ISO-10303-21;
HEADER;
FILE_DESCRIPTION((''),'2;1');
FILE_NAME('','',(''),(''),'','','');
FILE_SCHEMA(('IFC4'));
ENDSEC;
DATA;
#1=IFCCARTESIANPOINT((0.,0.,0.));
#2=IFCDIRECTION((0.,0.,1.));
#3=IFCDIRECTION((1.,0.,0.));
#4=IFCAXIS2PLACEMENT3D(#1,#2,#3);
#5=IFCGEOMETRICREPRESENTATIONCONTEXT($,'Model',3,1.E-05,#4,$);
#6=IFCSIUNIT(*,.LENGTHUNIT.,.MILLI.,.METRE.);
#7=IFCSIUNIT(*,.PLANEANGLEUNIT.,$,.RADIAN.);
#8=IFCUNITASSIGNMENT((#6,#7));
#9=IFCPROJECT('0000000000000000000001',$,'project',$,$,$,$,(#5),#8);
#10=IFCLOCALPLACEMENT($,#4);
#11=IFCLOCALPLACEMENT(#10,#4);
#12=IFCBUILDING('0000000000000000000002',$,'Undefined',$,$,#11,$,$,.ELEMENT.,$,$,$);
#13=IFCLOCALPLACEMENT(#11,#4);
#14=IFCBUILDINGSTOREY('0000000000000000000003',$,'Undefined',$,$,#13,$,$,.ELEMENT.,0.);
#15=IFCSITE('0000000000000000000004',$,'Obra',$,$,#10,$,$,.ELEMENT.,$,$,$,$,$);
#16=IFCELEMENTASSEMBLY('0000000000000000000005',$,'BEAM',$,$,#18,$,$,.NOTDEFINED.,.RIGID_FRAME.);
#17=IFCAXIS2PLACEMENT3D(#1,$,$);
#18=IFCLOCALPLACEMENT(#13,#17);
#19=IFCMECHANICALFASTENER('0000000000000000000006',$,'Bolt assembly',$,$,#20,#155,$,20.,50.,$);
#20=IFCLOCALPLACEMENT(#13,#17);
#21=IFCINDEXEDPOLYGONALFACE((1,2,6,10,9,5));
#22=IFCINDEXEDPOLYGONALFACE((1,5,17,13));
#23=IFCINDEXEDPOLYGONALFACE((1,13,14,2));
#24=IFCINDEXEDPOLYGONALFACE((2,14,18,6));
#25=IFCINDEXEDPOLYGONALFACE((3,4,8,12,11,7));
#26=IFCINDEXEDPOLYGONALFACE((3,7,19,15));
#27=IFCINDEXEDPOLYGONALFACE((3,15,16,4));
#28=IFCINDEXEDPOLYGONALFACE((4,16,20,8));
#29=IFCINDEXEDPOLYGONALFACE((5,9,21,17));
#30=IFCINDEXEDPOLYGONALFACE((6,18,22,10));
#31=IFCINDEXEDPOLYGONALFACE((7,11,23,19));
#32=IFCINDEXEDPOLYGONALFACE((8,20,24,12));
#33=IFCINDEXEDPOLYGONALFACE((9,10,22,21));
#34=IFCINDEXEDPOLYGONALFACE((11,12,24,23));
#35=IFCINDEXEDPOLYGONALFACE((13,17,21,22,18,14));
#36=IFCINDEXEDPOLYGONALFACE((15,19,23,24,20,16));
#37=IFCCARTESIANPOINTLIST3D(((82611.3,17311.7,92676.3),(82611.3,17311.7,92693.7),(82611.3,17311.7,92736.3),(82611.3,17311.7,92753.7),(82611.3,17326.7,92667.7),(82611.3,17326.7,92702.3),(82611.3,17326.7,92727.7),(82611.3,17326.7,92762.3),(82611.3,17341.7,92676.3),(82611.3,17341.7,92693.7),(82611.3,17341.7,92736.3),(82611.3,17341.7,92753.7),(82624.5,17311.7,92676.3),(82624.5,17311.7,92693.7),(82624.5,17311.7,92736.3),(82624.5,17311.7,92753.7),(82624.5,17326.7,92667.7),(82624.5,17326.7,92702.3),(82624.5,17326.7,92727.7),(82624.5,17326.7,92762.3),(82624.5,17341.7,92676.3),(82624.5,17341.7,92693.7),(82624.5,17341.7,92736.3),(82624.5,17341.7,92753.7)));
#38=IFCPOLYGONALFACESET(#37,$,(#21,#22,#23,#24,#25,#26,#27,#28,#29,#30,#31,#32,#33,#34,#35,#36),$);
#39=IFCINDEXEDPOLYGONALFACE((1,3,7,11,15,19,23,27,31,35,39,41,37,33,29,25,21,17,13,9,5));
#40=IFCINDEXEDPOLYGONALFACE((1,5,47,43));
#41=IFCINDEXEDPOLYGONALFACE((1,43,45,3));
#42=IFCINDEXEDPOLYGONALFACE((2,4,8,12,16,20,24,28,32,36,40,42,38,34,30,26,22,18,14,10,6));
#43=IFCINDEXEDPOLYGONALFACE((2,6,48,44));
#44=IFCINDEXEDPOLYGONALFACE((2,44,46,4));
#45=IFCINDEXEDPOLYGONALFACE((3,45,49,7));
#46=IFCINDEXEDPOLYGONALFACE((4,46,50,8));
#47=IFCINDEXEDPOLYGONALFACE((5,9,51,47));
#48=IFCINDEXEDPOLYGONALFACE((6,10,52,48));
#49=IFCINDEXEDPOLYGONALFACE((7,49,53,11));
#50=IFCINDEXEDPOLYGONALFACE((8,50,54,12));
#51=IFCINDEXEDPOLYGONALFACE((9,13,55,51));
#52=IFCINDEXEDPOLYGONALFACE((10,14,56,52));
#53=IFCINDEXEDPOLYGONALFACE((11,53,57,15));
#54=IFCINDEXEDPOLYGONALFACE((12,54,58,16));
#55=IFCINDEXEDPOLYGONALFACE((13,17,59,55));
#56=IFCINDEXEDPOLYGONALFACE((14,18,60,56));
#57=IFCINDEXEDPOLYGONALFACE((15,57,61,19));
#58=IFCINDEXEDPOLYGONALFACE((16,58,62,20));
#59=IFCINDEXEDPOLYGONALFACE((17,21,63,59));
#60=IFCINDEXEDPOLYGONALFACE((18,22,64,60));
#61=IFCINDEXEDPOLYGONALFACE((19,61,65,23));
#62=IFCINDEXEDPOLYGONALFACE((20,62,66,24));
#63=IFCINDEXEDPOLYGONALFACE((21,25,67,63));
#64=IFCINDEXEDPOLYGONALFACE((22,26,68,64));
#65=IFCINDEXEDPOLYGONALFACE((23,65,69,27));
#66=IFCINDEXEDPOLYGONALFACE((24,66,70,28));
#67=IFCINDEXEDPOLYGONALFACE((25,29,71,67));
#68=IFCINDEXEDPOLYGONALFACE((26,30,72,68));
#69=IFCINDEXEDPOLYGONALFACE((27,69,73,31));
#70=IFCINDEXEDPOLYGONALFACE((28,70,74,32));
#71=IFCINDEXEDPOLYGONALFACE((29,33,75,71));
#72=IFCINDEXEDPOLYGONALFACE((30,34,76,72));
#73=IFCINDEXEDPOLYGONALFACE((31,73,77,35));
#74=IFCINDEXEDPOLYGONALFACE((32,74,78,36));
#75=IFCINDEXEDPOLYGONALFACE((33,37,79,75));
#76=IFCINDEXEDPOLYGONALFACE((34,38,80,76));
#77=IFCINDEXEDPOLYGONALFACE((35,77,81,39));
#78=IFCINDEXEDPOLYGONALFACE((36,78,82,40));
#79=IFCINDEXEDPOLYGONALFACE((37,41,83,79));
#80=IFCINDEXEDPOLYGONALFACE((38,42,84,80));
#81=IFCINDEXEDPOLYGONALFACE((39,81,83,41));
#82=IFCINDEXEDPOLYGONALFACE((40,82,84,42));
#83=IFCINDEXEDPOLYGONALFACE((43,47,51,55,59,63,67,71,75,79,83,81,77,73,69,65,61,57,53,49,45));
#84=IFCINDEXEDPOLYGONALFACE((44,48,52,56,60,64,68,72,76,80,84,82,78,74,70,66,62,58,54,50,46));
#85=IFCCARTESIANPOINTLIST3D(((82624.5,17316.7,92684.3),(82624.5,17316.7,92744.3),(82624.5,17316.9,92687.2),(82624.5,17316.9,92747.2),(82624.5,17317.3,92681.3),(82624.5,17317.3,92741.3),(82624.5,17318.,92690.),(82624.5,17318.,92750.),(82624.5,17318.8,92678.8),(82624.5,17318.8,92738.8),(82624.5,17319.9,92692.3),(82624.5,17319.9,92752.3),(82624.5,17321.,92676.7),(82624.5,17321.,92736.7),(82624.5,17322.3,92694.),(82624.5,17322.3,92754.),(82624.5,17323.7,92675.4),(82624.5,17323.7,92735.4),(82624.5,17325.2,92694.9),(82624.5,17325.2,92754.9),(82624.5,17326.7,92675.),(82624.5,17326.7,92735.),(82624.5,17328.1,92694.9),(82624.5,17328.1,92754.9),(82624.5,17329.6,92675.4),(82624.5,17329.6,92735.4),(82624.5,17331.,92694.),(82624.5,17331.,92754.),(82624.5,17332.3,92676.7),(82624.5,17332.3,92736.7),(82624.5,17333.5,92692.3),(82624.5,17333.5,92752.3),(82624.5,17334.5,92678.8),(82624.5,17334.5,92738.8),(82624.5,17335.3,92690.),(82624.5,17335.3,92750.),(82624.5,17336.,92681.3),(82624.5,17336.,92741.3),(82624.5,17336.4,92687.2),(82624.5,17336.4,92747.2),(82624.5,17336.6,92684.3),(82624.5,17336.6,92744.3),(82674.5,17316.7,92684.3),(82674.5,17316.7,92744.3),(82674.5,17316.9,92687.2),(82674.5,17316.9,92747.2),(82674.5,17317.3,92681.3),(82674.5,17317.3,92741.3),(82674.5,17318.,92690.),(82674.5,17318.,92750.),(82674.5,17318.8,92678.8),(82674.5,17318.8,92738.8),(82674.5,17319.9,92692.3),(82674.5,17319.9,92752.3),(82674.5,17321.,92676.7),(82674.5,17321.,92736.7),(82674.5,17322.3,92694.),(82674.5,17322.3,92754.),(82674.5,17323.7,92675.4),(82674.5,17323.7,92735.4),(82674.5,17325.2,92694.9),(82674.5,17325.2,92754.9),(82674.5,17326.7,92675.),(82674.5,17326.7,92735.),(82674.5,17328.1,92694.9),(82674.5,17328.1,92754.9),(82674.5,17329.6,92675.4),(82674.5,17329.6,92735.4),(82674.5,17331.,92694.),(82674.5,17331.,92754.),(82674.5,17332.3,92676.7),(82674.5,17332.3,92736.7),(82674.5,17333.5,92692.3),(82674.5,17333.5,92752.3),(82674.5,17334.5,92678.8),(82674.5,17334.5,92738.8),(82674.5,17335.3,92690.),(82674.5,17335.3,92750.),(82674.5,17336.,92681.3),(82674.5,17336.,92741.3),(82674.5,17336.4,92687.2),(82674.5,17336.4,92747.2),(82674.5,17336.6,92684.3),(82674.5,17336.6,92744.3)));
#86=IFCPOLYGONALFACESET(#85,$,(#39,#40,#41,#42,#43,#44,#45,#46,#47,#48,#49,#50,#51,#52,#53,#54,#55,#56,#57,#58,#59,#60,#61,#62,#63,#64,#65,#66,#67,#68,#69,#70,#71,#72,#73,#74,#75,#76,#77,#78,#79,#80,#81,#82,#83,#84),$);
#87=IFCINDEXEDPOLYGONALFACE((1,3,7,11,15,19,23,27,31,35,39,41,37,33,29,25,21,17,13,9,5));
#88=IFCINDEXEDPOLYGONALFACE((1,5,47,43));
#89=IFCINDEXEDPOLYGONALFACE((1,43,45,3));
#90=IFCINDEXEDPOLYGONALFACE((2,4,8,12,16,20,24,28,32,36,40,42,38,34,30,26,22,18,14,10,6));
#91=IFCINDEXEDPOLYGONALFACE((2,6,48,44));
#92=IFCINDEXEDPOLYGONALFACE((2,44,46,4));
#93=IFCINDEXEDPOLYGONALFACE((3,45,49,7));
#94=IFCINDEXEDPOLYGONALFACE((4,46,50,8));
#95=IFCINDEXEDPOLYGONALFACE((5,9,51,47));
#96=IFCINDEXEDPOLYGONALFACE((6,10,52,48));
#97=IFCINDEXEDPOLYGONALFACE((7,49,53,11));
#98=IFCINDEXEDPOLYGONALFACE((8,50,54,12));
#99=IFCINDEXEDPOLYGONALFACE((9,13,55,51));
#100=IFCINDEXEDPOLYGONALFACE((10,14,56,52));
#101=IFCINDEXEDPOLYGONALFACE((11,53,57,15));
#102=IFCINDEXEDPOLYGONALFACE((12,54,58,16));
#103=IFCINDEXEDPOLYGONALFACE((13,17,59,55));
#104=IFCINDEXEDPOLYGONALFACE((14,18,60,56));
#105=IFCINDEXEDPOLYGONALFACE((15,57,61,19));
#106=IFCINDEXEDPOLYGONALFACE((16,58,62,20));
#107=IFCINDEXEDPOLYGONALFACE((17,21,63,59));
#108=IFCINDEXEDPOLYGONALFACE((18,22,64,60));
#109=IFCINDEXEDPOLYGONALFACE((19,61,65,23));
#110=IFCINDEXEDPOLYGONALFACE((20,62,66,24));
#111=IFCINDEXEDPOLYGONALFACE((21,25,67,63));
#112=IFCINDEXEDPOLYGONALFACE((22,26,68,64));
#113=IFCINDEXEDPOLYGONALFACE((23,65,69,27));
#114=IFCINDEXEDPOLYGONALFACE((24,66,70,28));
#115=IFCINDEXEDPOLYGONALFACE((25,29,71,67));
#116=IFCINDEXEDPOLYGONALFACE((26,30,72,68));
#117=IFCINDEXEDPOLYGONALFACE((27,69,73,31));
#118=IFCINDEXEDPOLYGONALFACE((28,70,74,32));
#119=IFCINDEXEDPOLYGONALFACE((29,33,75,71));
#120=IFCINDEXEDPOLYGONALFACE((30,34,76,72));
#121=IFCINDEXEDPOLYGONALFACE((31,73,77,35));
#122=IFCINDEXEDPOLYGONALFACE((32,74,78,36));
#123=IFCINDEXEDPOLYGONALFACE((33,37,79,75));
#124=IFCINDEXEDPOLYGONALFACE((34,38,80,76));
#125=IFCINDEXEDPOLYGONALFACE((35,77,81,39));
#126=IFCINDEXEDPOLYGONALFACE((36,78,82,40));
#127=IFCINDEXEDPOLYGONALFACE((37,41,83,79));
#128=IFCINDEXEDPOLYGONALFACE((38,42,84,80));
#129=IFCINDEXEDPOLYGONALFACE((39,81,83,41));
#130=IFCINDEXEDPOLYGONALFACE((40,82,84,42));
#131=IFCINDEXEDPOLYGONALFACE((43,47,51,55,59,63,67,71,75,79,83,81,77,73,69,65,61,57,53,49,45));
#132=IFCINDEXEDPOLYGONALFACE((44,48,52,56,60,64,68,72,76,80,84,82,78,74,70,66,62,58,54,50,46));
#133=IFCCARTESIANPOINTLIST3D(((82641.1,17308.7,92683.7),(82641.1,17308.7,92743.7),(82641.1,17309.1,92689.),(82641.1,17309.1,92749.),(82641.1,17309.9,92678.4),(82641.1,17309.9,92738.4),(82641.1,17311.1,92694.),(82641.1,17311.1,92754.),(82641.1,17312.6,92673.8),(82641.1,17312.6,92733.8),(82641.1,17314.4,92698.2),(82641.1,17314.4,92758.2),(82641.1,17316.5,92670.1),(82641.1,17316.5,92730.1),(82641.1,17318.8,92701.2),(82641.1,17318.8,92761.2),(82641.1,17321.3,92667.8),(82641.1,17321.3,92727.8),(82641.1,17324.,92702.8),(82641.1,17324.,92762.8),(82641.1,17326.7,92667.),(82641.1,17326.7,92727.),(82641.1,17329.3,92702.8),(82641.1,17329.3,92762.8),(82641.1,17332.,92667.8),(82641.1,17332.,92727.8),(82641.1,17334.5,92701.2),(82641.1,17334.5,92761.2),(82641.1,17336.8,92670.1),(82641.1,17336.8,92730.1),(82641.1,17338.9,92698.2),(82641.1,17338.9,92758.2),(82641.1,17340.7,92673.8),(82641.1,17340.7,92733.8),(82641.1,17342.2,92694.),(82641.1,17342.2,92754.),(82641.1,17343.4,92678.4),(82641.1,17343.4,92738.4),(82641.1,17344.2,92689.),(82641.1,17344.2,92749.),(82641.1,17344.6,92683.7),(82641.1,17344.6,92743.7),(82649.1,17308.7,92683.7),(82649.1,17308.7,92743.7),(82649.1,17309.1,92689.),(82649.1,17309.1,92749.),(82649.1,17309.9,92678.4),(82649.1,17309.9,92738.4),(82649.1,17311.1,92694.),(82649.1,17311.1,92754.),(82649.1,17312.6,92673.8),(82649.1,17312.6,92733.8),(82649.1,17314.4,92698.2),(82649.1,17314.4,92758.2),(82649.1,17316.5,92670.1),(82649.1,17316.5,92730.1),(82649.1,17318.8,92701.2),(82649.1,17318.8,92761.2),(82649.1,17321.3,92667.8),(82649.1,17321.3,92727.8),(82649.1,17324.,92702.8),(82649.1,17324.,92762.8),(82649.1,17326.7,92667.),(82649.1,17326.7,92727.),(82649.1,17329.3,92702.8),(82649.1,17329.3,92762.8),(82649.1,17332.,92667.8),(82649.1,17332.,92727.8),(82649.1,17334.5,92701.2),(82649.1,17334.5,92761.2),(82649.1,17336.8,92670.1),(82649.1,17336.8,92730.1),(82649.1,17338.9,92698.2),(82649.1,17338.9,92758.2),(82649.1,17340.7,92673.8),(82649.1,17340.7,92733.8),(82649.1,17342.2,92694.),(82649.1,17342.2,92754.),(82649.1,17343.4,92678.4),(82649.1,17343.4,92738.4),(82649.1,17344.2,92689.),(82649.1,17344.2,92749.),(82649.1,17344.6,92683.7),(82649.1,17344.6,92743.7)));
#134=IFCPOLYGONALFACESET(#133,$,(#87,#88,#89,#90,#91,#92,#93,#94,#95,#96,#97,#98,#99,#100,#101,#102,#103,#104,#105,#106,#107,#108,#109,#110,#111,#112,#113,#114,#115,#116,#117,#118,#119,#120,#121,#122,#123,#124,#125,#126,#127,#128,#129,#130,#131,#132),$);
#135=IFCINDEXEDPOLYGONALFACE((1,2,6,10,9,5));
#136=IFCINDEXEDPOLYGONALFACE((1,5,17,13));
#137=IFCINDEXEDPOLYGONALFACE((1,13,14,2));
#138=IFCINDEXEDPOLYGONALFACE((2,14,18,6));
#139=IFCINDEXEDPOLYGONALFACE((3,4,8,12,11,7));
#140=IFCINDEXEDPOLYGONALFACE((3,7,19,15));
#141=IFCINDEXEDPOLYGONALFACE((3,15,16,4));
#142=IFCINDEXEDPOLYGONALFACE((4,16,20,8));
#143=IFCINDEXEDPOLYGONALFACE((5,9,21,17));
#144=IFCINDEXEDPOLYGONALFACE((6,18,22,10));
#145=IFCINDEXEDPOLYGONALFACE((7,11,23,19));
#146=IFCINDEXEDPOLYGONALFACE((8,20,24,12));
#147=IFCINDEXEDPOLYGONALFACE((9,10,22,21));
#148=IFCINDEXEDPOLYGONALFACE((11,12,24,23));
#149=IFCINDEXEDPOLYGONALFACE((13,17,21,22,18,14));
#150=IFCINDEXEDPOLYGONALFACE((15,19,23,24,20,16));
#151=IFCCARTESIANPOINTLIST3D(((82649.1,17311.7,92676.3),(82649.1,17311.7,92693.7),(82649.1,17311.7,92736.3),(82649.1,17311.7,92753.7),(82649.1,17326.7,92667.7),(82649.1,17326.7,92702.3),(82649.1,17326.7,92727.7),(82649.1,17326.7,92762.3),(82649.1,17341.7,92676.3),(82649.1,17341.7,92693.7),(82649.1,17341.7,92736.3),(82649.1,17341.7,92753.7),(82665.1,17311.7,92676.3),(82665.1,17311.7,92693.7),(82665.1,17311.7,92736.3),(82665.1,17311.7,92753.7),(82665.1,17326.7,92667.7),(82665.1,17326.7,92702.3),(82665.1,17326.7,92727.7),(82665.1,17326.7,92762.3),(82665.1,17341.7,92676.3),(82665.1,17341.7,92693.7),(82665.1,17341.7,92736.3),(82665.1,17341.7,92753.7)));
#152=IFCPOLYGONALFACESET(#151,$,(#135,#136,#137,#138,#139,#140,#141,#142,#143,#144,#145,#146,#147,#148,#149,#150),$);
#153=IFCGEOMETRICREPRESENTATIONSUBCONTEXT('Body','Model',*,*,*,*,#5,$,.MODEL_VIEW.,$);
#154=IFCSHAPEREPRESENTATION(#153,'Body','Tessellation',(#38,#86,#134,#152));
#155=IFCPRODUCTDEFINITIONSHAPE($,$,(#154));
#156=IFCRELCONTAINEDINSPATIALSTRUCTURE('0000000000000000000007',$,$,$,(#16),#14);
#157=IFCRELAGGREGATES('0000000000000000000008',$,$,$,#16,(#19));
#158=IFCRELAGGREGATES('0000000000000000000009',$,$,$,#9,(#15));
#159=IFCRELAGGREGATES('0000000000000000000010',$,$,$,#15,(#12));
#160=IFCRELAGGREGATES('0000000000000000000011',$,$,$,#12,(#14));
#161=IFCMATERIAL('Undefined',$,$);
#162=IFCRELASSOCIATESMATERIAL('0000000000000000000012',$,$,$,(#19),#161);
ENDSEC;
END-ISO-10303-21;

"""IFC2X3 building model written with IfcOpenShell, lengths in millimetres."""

from ifc_helpers import new_model, si_unit, frame, origin_with_axes, origin_2d_with_axis, place, context, subcontext, project, spatial, polyline, circle, outline, extrude, source, transform, mapped, material, element, aggregate, save


model = new_model("IFC2X3")

# Units and contexts
model_context = context("Model", 3, precision=1e-05, world=origin_with_axes())
body_context = subcontext(model_context, "Body", "Model", "MODEL_VIEW")
ifc_project = project(units=[si_unit("LENGTHUNIT", "METRE", prefix="MILLI"), si_unit("PLANEANGLEUNIT", "RADIAN")], contexts=[model_context])

# Site, building, storey
site_placement = place(None, origin_with_axes())
site = spatial("IfcSite", under=ifc_project, at=site_placement, Name="Obra", CompositionType="ELEMENT")
building_placement = place(site_placement, origin_with_axes())
building = spatial("IfcBuilding", under=site, at=building_placement, Name="Undefined", CompositionType="ELEMENT")
storey_placement = place(building_placement, origin_with_axes())
storey = spatial("IfcBuildingStorey", under=building, at=storey_placement, Name="Undefined", CompositionType="ELEMENT", Elevation=0.0)

# Shared definitions
ifc_material_1 = material(Name="Undefined")
shared_shape_1 = source(origin_with_axes(), body_context, "Body", "SweptSolid", [
    extrude(outline(polyline([(17.3, 0.0), (8.7, 15.0), (-8.7, 15.0), (-17.3, 0.0), (-8.7, -15.0), (8.7, -15.0), (17.3, 0.0)])), frame((0.0, -26.5, 0.0), z_axis=(0.0, 1.0, 0.0), x_axis=(1.0, 0.0, 0.0)), (0.0, 0.0, 1.0), 13.2),
    extrude(circle(Radius=10.0, at=origin_2d_with_axis()), frame((0.0, -13.3, 0.0), z_axis=(0.0, 1.0, 0.0), x_axis=(1.0, 0.0, 0.0)), (0.0, 0.0, 1.0), 50.0),
    extrude(circle(Radius=18.0, at=origin_2d_with_axis()), frame((0.0, 3.3, 0.0), z_axis=(0.0, 1.0, 0.0), x_axis=(1.0, 0.0, 0.0)), (0.0, 0.0, 1.0), 8.0),
    extrude(outline(polyline([(17.3, 0.0), (8.7, 15.0), (-8.7, 15.0), (-17.3, 0.0), (-8.7, -15.0), (8.7, -15.0), (17.3, 0.0)])), frame((0.0, 11.3, 0.0), z_axis=(0.0, 1.0, 0.0), x_axis=(1.0, 0.0, 0.0)), (0.0, 0.0, 1.0), 16.0),
])

# Element assembly, mechanical fastener
assembly_1_placement = place(storey_placement, origin_with_axes())
assembly_1 = element("IfcElementAssembly", 1, at=assembly_1_placement, inside=storey, Name="BEAM", AssemblyPlace="NOTDEFINED", PredefinedType="RIGID_FRAME")
mechanical_fastener_1_placement = place(assembly_1_placement, frame((82637.8, 17366.7, 92850.0), z_axis=(0.0, -1.0, 0.0), x_axis=(0.0, 0.0, -1.0)))
mechanical_fastener_1 = element("IfcMechanicalFastener", 2, at=mechanical_fastener_1_placement, material=ifc_material_1, Name="Bolt assembly", NominalDiameter=20.0, NominalLength=50.0, context=body_context, shape_type="MappedRepresentation", body=[
    mapped(shared_shape_1, transform((105.0, 0.0, 40.0))),
    mapped(shared_shape_1, transform((165.0, 0.0, 40.0))),
])
aggregate(assembly_1, [mechanical_fastener_1])

save(model, "model.ifc")
